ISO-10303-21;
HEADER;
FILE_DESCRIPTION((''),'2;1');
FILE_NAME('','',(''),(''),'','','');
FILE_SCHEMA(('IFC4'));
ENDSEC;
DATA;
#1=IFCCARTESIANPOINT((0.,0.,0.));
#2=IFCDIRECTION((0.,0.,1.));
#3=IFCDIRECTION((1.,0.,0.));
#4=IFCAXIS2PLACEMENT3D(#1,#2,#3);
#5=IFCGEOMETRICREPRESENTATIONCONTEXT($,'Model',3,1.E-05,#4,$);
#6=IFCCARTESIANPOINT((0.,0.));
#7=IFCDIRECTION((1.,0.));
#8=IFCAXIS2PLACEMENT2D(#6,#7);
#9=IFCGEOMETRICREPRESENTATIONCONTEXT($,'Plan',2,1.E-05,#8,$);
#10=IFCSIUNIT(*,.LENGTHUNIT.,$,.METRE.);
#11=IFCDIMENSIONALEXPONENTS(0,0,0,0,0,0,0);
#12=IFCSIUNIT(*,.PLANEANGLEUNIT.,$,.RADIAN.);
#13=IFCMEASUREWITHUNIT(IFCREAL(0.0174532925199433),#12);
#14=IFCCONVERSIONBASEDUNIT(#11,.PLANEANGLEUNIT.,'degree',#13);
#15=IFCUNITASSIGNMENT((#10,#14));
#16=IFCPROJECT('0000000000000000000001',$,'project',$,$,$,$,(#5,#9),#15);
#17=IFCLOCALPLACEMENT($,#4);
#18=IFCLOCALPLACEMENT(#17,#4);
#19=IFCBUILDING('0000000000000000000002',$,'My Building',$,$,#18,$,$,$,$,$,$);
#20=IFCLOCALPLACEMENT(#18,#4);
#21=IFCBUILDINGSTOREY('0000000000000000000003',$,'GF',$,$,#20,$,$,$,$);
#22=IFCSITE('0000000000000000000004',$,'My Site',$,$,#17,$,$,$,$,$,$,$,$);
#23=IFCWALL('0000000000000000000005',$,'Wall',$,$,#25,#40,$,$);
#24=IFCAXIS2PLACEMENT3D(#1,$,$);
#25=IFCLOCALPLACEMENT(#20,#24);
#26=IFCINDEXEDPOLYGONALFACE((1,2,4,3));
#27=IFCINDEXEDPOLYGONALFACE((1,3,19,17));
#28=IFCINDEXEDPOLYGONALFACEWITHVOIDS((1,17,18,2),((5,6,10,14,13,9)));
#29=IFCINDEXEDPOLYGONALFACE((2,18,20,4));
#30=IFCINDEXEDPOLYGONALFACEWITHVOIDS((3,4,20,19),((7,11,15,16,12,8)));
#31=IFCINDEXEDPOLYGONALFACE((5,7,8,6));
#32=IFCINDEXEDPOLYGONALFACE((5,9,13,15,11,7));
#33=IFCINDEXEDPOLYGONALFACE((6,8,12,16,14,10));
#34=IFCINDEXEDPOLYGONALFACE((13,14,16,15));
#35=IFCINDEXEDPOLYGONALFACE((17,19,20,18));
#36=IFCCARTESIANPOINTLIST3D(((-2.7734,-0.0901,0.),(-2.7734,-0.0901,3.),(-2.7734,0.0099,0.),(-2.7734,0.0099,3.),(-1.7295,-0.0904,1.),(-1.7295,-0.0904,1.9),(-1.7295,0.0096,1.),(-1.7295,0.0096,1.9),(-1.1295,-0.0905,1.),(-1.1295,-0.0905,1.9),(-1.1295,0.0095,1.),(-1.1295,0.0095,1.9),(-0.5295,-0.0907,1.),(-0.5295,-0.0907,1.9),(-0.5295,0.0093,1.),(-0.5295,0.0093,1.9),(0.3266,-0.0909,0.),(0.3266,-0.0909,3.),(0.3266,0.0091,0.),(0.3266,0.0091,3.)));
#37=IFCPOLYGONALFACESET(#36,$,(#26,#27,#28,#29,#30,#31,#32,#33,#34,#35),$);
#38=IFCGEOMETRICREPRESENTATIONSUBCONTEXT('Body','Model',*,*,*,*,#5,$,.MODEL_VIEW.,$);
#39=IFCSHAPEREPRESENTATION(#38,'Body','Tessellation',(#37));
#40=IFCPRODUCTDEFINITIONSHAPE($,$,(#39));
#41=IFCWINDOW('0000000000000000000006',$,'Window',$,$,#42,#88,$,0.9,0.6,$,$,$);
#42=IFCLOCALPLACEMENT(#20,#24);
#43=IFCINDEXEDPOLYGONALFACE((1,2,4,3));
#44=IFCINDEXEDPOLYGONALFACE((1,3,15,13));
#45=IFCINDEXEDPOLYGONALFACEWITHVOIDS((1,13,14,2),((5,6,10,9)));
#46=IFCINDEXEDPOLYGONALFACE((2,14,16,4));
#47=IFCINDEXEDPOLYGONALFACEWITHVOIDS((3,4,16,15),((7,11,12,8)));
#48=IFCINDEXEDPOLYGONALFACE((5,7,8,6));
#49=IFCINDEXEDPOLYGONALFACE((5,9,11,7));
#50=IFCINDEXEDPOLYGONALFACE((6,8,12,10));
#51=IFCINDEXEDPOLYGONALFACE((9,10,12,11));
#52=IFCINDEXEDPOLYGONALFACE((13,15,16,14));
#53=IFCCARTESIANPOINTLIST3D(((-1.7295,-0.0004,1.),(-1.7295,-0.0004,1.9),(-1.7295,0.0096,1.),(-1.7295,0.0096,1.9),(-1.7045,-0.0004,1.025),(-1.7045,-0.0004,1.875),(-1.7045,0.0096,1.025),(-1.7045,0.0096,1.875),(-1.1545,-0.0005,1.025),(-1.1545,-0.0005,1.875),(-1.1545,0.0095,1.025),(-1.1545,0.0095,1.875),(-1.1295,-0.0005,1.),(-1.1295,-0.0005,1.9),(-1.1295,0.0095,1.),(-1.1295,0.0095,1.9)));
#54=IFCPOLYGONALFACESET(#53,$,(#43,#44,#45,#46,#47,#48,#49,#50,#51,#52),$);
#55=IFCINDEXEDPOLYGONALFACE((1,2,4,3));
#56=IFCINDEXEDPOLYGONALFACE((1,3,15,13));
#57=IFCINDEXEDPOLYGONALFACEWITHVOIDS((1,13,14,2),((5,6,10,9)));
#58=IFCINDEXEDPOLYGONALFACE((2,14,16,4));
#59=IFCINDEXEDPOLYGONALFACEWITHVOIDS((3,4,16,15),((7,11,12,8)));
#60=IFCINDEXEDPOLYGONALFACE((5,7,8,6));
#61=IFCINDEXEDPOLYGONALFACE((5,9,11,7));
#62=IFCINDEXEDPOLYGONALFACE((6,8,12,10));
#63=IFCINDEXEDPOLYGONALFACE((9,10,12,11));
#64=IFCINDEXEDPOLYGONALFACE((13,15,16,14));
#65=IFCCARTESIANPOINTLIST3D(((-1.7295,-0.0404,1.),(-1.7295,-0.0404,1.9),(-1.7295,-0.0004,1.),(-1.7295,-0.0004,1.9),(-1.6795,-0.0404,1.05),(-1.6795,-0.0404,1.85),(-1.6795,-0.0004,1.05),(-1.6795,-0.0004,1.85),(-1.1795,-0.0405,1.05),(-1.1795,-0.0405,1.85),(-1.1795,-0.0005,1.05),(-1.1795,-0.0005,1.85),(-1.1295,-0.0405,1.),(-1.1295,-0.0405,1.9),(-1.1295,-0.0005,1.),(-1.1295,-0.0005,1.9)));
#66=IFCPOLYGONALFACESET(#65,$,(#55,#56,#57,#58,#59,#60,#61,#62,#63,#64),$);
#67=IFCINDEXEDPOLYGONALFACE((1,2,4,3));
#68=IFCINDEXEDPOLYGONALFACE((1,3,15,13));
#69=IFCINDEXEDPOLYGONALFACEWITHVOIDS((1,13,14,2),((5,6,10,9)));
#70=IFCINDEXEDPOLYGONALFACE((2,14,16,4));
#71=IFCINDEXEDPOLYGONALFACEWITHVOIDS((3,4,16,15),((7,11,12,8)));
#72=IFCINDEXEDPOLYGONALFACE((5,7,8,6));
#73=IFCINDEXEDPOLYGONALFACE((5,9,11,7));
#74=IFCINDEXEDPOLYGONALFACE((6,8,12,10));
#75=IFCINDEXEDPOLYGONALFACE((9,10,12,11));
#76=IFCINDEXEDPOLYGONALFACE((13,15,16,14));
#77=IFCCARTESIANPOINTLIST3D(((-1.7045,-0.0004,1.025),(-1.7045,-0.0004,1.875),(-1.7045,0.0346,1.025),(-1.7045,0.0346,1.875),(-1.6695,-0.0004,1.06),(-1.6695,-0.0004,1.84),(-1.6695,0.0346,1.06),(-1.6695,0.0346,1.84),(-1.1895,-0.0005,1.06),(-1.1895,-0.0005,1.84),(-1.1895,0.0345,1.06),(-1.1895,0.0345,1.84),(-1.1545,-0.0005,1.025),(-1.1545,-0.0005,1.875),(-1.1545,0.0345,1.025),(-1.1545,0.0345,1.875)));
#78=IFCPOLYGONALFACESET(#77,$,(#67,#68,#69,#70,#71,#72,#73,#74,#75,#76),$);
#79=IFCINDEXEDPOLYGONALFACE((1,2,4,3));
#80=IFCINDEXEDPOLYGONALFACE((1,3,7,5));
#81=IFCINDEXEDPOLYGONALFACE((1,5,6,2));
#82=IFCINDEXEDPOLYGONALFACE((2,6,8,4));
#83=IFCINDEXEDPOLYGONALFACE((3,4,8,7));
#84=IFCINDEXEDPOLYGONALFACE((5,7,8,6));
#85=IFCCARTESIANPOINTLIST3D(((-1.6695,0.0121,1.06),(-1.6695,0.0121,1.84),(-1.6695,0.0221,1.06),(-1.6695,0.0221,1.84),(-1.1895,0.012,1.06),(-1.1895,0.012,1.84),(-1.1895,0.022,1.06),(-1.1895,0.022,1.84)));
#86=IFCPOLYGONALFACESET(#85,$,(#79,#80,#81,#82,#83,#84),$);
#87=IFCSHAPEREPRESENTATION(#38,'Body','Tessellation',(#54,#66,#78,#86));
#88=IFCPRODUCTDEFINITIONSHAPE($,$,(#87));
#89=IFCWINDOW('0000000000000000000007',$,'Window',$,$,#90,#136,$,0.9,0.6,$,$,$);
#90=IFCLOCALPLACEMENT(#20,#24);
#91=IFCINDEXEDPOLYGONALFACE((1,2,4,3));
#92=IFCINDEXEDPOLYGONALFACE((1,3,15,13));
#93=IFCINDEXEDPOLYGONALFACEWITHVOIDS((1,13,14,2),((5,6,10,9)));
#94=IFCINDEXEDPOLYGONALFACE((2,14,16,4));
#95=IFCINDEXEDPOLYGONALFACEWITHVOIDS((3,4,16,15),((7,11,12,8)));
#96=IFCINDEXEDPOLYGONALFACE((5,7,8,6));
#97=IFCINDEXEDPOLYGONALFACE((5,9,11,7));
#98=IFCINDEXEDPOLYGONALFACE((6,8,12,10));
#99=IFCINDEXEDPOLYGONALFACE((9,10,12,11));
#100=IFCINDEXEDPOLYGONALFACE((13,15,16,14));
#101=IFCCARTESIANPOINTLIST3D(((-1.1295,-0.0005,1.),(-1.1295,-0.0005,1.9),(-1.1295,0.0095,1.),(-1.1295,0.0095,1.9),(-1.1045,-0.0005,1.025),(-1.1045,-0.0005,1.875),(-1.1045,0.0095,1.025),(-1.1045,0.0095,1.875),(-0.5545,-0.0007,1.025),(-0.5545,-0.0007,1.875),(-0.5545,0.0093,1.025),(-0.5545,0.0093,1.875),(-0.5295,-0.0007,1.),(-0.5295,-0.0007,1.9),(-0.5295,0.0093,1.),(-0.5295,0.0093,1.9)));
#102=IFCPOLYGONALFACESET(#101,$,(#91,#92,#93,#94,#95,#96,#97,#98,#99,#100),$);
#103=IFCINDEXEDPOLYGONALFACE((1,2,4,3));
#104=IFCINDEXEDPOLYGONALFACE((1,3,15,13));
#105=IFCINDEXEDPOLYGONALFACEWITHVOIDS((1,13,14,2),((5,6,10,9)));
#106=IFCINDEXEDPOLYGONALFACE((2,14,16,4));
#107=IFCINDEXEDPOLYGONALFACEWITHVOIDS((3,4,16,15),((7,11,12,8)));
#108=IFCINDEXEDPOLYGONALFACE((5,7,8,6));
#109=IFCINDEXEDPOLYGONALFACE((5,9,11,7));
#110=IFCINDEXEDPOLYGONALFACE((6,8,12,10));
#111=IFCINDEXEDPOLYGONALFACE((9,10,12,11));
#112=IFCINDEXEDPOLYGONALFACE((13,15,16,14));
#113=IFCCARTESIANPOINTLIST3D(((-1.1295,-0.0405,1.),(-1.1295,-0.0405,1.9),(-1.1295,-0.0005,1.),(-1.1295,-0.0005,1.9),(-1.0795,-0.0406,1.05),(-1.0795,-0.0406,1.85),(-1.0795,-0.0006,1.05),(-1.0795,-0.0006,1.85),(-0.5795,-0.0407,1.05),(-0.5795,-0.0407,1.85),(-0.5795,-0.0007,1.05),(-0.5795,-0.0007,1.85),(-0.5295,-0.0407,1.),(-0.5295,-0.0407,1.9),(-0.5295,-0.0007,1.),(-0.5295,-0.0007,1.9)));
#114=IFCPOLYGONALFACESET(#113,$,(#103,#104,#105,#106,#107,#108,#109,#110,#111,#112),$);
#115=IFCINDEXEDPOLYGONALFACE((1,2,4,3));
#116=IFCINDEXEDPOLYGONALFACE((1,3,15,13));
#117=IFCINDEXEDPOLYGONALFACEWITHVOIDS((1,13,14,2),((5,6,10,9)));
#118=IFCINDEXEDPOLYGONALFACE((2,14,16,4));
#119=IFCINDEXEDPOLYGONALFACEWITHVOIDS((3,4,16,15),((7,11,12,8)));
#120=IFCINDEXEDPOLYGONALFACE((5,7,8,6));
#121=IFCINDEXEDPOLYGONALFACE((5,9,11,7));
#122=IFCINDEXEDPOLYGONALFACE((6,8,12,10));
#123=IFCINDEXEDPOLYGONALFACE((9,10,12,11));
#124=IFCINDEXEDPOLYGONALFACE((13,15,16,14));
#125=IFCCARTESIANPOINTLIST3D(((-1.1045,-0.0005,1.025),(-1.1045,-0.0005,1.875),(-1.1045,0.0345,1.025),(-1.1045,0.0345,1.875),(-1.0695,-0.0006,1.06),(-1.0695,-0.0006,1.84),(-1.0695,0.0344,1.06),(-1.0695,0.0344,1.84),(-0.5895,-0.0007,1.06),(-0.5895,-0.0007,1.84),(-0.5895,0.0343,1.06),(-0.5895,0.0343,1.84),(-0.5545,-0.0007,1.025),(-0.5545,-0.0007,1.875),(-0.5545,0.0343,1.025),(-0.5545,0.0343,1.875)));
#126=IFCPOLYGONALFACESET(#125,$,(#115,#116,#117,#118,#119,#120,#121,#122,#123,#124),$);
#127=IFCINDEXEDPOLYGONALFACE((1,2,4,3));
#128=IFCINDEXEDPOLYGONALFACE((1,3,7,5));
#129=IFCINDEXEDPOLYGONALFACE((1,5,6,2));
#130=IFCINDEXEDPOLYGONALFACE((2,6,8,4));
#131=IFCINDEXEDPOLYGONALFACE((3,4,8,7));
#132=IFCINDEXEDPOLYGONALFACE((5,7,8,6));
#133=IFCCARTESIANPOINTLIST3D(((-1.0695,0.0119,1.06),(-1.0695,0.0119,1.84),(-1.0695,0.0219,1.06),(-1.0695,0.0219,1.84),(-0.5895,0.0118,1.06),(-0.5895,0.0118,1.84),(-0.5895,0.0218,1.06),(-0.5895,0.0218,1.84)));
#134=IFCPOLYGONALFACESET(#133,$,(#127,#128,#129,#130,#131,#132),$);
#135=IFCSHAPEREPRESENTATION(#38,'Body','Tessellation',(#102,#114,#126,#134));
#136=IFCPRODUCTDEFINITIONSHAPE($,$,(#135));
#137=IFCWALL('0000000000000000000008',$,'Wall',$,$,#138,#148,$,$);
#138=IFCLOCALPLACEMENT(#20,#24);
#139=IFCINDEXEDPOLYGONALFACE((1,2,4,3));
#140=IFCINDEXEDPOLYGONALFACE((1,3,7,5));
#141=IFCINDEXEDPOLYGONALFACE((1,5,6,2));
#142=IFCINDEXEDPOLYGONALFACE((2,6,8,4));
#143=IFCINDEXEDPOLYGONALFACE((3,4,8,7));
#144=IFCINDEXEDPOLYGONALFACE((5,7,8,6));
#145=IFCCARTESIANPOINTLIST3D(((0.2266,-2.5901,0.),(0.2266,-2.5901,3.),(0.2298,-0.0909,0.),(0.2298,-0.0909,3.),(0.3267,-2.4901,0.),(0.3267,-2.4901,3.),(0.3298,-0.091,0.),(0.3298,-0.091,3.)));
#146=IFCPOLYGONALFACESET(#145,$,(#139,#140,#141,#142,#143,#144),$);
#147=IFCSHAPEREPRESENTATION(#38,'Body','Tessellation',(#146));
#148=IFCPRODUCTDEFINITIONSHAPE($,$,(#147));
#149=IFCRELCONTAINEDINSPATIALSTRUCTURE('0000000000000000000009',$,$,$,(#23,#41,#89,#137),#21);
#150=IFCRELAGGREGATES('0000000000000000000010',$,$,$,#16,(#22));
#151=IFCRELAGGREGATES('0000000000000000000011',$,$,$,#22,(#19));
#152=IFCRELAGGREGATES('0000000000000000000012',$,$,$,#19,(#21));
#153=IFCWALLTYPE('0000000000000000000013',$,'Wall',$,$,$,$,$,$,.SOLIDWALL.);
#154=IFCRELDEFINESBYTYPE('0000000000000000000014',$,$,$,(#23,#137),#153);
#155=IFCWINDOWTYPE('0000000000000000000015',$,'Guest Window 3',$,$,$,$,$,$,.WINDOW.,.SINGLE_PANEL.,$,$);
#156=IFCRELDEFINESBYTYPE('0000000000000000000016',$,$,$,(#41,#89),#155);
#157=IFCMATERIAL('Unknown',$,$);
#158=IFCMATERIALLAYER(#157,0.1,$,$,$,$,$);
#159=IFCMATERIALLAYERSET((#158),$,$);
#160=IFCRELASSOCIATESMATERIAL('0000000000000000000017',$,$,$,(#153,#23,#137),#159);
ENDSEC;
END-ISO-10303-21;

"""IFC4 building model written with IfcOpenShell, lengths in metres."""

from ifc_helpers import new_model, entity, si_unit, converted_unit, frame, origin_with_axes, origin_2d_with_axis, place, context, subcontext, project, spatial, line, indexed_curve, outline, extrude, shape, source, transform, mapped, material, layer, layer_set, layer_usage, type_object, type_shapes, element, fill, save


model = new_model("IFC4")

# Units and contexts
model_context = context("Model", 3, precision=1e-05, world=origin_with_axes())
plan_context = context("Plan", 2, precision=1e-05, world=origin_2d_with_axis())
body_context_1 = subcontext(model_context, "Body", "Model", "MODEL_VIEW")
body_context_2 = subcontext(plan_context, "Body", "Plan", "PLAN_VIEW")
ifc_project = project(units=[si_unit("LENGTHUNIT", "METRE"), converted_unit("PLANEANGLEUNIT", "degree", entity("IfcReal", 0.0174532925199433), si_unit("PLANEANGLEUNIT", "RADIAN"), dimensions=[0, 0, 0, 0, 0, 0, 0])], contexts=[model_context, plan_context])

# Site, building, storey
site_placement = place(None, origin_with_axes())
site = spatial("IfcSite", under=ifc_project, at=site_placement, Name="My Site")
building_placement = place(site_placement, origin_with_axes())
building = spatial("IfcBuilding", under=site, at=building_placement, Name="My Building")
storey_placement = place(building_placement, origin_with_axes())
storey = spatial("IfcBuildingStorey", under=building, at=storey_placement, Name="GF")

# Shared definitions
ifc_material_1 = material(Name="Unknown")

# Shared definitions
ifc_layer_1 = layer(ifc_material_1, 0.1)
ifc_layer_set_1 = layer_set([ifc_layer_1])
wall_type = type_object("IfcWallType", Name="Wall", PredefinedType="SOLIDWALL", material=ifc_layer_set_1)

# Wall, openings, windows
ifc_layer_usage_1 = layer_usage(ifc_layer_set_1, "AXIS2", "POSITIVE", 0.0)
wall_1_placement = place(storey_placement, frame((-2.7734, -0.0901, 0.0), z_axis=(0.0, 0.0, 1.0), x_axis=(1.0, -0.000264, 0.0)))
wall_1 = element("IfcWall", 1, at=wall_1_placement, inside=storey, type_object=wall_type, material=ifc_layer_usage_1, Name="Wall", context=body_context_1, shape_type="SweptSolid", body=[
    extrude(outline(indexed_curve([(0.0, 0.0), (0.0, 0.1), (3.1, 0.1), (3.1, 0.0)], segments=[line(1, 2, 3, 4, 1)])), origin_with_axes(), (0.0, 0.0, 1.0), 3.0),
])
shared_shape_1 = source(origin_with_axes(), body_context_1, "Body", "SweptSolid", [
    extrude(outline(indexed_curve([(0.0, 0.0), (0.6, 0.0), (0.6, 0.9), (0.0, 0.9)], segments=[line(1, 2, 3, 4, 1)])), frame((0.0, -0.6, 0.0), z_axis=(0.0, -1.0, 0.0), x_axis=(1.0, 0.0, 0.0)), (0.0, 0.0, -1.0), 1.2),
])
opening_1_placement = place(wall_1_placement, frame((1.0439, 0.0, 1.0), z_axis=(0.0, 0.0, 1.0), x_axis=(1.0, 0.0, 0.0)))
opening_1 = element("IfcOpeningElement", 2, at=opening_1_placement, cuts=wall_1, PredefinedType="OPENING", context=body_context_1, shape_type="MappedRepresentation", body=[
    mapped(shared_shape_1, transform((0.0, 0.0, 0.0), x_axis=(1.0, 0.0, 0.0), y_axis=(0.0, 1.0, 0.0), z_axis=(0.0, 0.0, 1.0), scale=1.0)),
])
opening_2_placement = place(wall_1_placement, frame((1.6439, 0.0, 1.0), z_axis=(0.0, 0.0, 1.0), x_axis=(1.0, 0.0, 0.0)))
opening_2 = element("IfcOpeningElement", 3, at=opening_2_placement, cuts=wall_1, PredefinedType="OPENING", context=body_context_1, shape_type="MappedRepresentation", body=[
    mapped(shared_shape_1, transform((0.0, 0.0, 0.0), x_axis=(1.0, 0.0, 0.0), y_axis=(0.0, 1.0, 0.0), z_axis=(0.0, 0.0, 1.0), scale=1.0)),
])
window_type_1 = type_object("IfcWindowType", Name="Guest Window 3", PartitioningType="SINGLE_PANEL", PredefinedType="WINDOW")
shared_shape_2 = source(origin_with_axes(), body_context_1, "Body", "SweptSolid", [
    extrude(outline(indexed_curve([(0.0, 0.0), (0.6, 0.0), (0.6, 0.9), (0.0, 0.9)], segments=[line(1, 2, 3, 4, 1)]), holes=[indexed_curve([(0.025, 0.025), (0.575, 0.025), (0.575, 0.875), (0.025, 0.875)], segments=[line(1, 2, 3, 4, 1)])]), frame((0.0, 0.09, 0.0), z_axis=(0.0, -1.0, 0.0), x_axis=(1.0, 0.0, 0.0)), (0.0, 0.0, -1.0), 0.01),
    extrude(outline(indexed_curve([(0.0, 0.0), (0.6, 0.0), (0.6, 0.9), (0.0, 0.9)], segments=[line(1, 2, 3, 4, 1)]), holes=[indexed_curve([(0.05, 0.05), (0.55, 0.05), (0.55, 0.85), (0.05, 0.85)], segments=[line(1, 2, 3, 4, 1)])]), frame((0.0, 0.05, 0.0), z_axis=(0.0, -1.0, 0.0), x_axis=(1.0, 0.0, 0.0)), (0.0, 0.0, -1.0), 0.04),
    extrude(outline(indexed_curve([(0.0, 0.0), (0.55, 0.0), (0.55, 0.85), (0.0, 0.85)], segments=[line(1, 2, 3, 4, 1)]), holes=[indexed_curve([(0.035, 0.035), (0.515, 0.035), (0.515, 0.815), (0.035, 0.815)], segments=[line(1, 2, 3, 4, 1)])]), frame((0.025, 0.09, 0.025), z_axis=(0.0, -1.0, 0.0), x_axis=(1.0, 0.0, 0.0)), (0.0, 0.0, -1.0), 0.035),
    extrude(outline(indexed_curve([(0.035, 0.035), (0.515, 0.035), (0.515, 0.815), (0.035, 0.815)], segments=[line(1, 2, 3, 4, 1)])), frame((0.025, 0.1025, 0.025), z_axis=(0.0, -1.0, 0.0), x_axis=(1.0, 0.0, 0.0)), (0.0, 0.0, -1.0), 0.01),
])
shared_shape_3 = source(origin_with_axes(), body_context_2, "Body", "Curve2D", [
    entity("IfcIndexedPolyCurve", entity("IfcCartesianPointList2D", [[0.05, 0.05], [0.55, 0.05]])),
    entity("IfcIndexedPolyCurve", entity("IfcCartesianPointList2D", [[0.0, 0.1], [0.025, 0.1], [0.025, 0.09], [0.05, 0.09], [0.05, 0.05], [0.0, 0.05]]), [entity("IfcLineIndex", [1, 2, 3, 4, 5, 6, 1])]),
    entity("IfcIndexedPolyCurve", entity("IfcCartesianPointList2D", [[0.6, 0.1], [0.575, 0.1], [0.575, 0.09], [0.55, 0.09], [0.55, 0.05], [0.6, 0.05]]), [entity("IfcLineIndex", [1, 2, 3, 4, 5, 6, 1])]),
    entity("IfcIndexedPolyCurve", entity("IfcCartesianPointList2D", [[0.025, 0.09], [0.06, 0.09], [0.06, 0.125], [0.025, 0.125]]), [entity("IfcLineIndex", [1, 2, 3, 4, 1])]),
    entity("IfcIndexedPolyCurve", entity("IfcCartesianPointList2D", [[0.575, 0.09], [0.54, 0.09], [0.54, 0.125], [0.575, 0.125]]), [entity("IfcLineIndex", [1, 2, 3, 4, 1])]),
    entity("IfcIndexedPolyCurve", entity("IfcCartesianPointList2D", [[0.06, 0.09], [0.54, 0.09]])),
    entity("IfcIndexedPolyCurve", entity("IfcCartesianPointList2D", [[0.06, 0.125], [0.54, 0.125]])),
    entity("IfcIndexedPolyCurve", entity("IfcCartesianPointList2D", [[0.06, 0.1075], [0.54, 0.1075]])),
])
type_shapes(window_type_1, [shared_shape_2, shared_shape_3])
window_1_placement = place(opening_1_placement, frame((0.0, 0.0, 0.0), z_axis=(0.0, 0.0, 1.0), x_axis=(1.0, 0.0, 0.0)))
window_1 = element("IfcWindow", 4, at=window_1_placement, inside=storey, type_object=window_type_1, Name="Window", OverallHeight=0.9, OverallWidth=0.6, shapes=[
    shape(body_context_1, "Body", "MappedRepresentation", [mapped(shared_shape_2, transform((0.0, 0.0, 0.0), x_axis=(1.0, 0.0, 0.0), y_axis=(0.0, 1.0, 0.0), z_axis=(0.0, 0.0, 1.0), scale=1.0))]),
    shape(body_context_2, "Body", "MappedRepresentation", [mapped(shared_shape_3, transform((0.0, 0.0, 0.0), x_axis=(1.0, 0.0, 0.0), y_axis=(0.0, 1.0, 0.0), z_axis=(0.0, 0.0, 1.0), scale=1.0))]),
])
fill(opening_1, window_1)
window_2_placement = place(opening_2_placement, frame((0.0, 0.0, 0.0), z_axis=(0.0, 0.0, 1.0), x_axis=(1.0, 0.0, 0.0)))
window_2 = element("IfcWindow", 5, at=window_2_placement, inside=storey, type_object=window_type_1, Name="Window", OverallHeight=0.9, OverallWidth=0.6, shapes=[
    shape(body_context_1, "Body", "MappedRepresentation", [mapped(shared_shape_2, transform((0.0, 0.0, 0.0), x_axis=(1.0, 0.0, 0.0), y_axis=(0.0, 1.0, 0.0), z_axis=(0.0, 0.0, 1.0), scale=1.0))]),
    shape(body_context_2, "Body", "MappedRepresentation", [mapped(shared_shape_3, transform((0.0, 0.0, 0.0), x_axis=(1.0, 0.0, 0.0), y_axis=(0.0, 1.0, 0.0), z_axis=(0.0, 0.0, 1.0), scale=1.0))]),
])
fill(opening_2, window_2)

# Wall
ifc_layer_usage_2 = layer_usage(ifc_layer_set_1, "AXIS2", "POSITIVE", 0.0)
wall_2_placement = place(storey_placement, frame((0.2298, -0.0909, 0.0), z_axis=(0.0, 0.0, 1.0), x_axis=(-0.001286, -0.999999, 0.0)))
element("IfcWall", 6, at=wall_2_placement, inside=storey, type_object=wall_type, material=ifc_layer_usage_2, Name="Wall", context=body_context_1, shape_type="SweptSolid", body=[
    extrude(outline(indexed_curve([(0.0, 0.0), (0.0, 0.1), (2.3991, 0.1), (2.4992, 0.0)], segments=[line(1, 2, 3, 4, 1)])), origin_with_axes(), (0.0, 0.0, 1.0), 3.0),
])

save(model, "model.ifc")
